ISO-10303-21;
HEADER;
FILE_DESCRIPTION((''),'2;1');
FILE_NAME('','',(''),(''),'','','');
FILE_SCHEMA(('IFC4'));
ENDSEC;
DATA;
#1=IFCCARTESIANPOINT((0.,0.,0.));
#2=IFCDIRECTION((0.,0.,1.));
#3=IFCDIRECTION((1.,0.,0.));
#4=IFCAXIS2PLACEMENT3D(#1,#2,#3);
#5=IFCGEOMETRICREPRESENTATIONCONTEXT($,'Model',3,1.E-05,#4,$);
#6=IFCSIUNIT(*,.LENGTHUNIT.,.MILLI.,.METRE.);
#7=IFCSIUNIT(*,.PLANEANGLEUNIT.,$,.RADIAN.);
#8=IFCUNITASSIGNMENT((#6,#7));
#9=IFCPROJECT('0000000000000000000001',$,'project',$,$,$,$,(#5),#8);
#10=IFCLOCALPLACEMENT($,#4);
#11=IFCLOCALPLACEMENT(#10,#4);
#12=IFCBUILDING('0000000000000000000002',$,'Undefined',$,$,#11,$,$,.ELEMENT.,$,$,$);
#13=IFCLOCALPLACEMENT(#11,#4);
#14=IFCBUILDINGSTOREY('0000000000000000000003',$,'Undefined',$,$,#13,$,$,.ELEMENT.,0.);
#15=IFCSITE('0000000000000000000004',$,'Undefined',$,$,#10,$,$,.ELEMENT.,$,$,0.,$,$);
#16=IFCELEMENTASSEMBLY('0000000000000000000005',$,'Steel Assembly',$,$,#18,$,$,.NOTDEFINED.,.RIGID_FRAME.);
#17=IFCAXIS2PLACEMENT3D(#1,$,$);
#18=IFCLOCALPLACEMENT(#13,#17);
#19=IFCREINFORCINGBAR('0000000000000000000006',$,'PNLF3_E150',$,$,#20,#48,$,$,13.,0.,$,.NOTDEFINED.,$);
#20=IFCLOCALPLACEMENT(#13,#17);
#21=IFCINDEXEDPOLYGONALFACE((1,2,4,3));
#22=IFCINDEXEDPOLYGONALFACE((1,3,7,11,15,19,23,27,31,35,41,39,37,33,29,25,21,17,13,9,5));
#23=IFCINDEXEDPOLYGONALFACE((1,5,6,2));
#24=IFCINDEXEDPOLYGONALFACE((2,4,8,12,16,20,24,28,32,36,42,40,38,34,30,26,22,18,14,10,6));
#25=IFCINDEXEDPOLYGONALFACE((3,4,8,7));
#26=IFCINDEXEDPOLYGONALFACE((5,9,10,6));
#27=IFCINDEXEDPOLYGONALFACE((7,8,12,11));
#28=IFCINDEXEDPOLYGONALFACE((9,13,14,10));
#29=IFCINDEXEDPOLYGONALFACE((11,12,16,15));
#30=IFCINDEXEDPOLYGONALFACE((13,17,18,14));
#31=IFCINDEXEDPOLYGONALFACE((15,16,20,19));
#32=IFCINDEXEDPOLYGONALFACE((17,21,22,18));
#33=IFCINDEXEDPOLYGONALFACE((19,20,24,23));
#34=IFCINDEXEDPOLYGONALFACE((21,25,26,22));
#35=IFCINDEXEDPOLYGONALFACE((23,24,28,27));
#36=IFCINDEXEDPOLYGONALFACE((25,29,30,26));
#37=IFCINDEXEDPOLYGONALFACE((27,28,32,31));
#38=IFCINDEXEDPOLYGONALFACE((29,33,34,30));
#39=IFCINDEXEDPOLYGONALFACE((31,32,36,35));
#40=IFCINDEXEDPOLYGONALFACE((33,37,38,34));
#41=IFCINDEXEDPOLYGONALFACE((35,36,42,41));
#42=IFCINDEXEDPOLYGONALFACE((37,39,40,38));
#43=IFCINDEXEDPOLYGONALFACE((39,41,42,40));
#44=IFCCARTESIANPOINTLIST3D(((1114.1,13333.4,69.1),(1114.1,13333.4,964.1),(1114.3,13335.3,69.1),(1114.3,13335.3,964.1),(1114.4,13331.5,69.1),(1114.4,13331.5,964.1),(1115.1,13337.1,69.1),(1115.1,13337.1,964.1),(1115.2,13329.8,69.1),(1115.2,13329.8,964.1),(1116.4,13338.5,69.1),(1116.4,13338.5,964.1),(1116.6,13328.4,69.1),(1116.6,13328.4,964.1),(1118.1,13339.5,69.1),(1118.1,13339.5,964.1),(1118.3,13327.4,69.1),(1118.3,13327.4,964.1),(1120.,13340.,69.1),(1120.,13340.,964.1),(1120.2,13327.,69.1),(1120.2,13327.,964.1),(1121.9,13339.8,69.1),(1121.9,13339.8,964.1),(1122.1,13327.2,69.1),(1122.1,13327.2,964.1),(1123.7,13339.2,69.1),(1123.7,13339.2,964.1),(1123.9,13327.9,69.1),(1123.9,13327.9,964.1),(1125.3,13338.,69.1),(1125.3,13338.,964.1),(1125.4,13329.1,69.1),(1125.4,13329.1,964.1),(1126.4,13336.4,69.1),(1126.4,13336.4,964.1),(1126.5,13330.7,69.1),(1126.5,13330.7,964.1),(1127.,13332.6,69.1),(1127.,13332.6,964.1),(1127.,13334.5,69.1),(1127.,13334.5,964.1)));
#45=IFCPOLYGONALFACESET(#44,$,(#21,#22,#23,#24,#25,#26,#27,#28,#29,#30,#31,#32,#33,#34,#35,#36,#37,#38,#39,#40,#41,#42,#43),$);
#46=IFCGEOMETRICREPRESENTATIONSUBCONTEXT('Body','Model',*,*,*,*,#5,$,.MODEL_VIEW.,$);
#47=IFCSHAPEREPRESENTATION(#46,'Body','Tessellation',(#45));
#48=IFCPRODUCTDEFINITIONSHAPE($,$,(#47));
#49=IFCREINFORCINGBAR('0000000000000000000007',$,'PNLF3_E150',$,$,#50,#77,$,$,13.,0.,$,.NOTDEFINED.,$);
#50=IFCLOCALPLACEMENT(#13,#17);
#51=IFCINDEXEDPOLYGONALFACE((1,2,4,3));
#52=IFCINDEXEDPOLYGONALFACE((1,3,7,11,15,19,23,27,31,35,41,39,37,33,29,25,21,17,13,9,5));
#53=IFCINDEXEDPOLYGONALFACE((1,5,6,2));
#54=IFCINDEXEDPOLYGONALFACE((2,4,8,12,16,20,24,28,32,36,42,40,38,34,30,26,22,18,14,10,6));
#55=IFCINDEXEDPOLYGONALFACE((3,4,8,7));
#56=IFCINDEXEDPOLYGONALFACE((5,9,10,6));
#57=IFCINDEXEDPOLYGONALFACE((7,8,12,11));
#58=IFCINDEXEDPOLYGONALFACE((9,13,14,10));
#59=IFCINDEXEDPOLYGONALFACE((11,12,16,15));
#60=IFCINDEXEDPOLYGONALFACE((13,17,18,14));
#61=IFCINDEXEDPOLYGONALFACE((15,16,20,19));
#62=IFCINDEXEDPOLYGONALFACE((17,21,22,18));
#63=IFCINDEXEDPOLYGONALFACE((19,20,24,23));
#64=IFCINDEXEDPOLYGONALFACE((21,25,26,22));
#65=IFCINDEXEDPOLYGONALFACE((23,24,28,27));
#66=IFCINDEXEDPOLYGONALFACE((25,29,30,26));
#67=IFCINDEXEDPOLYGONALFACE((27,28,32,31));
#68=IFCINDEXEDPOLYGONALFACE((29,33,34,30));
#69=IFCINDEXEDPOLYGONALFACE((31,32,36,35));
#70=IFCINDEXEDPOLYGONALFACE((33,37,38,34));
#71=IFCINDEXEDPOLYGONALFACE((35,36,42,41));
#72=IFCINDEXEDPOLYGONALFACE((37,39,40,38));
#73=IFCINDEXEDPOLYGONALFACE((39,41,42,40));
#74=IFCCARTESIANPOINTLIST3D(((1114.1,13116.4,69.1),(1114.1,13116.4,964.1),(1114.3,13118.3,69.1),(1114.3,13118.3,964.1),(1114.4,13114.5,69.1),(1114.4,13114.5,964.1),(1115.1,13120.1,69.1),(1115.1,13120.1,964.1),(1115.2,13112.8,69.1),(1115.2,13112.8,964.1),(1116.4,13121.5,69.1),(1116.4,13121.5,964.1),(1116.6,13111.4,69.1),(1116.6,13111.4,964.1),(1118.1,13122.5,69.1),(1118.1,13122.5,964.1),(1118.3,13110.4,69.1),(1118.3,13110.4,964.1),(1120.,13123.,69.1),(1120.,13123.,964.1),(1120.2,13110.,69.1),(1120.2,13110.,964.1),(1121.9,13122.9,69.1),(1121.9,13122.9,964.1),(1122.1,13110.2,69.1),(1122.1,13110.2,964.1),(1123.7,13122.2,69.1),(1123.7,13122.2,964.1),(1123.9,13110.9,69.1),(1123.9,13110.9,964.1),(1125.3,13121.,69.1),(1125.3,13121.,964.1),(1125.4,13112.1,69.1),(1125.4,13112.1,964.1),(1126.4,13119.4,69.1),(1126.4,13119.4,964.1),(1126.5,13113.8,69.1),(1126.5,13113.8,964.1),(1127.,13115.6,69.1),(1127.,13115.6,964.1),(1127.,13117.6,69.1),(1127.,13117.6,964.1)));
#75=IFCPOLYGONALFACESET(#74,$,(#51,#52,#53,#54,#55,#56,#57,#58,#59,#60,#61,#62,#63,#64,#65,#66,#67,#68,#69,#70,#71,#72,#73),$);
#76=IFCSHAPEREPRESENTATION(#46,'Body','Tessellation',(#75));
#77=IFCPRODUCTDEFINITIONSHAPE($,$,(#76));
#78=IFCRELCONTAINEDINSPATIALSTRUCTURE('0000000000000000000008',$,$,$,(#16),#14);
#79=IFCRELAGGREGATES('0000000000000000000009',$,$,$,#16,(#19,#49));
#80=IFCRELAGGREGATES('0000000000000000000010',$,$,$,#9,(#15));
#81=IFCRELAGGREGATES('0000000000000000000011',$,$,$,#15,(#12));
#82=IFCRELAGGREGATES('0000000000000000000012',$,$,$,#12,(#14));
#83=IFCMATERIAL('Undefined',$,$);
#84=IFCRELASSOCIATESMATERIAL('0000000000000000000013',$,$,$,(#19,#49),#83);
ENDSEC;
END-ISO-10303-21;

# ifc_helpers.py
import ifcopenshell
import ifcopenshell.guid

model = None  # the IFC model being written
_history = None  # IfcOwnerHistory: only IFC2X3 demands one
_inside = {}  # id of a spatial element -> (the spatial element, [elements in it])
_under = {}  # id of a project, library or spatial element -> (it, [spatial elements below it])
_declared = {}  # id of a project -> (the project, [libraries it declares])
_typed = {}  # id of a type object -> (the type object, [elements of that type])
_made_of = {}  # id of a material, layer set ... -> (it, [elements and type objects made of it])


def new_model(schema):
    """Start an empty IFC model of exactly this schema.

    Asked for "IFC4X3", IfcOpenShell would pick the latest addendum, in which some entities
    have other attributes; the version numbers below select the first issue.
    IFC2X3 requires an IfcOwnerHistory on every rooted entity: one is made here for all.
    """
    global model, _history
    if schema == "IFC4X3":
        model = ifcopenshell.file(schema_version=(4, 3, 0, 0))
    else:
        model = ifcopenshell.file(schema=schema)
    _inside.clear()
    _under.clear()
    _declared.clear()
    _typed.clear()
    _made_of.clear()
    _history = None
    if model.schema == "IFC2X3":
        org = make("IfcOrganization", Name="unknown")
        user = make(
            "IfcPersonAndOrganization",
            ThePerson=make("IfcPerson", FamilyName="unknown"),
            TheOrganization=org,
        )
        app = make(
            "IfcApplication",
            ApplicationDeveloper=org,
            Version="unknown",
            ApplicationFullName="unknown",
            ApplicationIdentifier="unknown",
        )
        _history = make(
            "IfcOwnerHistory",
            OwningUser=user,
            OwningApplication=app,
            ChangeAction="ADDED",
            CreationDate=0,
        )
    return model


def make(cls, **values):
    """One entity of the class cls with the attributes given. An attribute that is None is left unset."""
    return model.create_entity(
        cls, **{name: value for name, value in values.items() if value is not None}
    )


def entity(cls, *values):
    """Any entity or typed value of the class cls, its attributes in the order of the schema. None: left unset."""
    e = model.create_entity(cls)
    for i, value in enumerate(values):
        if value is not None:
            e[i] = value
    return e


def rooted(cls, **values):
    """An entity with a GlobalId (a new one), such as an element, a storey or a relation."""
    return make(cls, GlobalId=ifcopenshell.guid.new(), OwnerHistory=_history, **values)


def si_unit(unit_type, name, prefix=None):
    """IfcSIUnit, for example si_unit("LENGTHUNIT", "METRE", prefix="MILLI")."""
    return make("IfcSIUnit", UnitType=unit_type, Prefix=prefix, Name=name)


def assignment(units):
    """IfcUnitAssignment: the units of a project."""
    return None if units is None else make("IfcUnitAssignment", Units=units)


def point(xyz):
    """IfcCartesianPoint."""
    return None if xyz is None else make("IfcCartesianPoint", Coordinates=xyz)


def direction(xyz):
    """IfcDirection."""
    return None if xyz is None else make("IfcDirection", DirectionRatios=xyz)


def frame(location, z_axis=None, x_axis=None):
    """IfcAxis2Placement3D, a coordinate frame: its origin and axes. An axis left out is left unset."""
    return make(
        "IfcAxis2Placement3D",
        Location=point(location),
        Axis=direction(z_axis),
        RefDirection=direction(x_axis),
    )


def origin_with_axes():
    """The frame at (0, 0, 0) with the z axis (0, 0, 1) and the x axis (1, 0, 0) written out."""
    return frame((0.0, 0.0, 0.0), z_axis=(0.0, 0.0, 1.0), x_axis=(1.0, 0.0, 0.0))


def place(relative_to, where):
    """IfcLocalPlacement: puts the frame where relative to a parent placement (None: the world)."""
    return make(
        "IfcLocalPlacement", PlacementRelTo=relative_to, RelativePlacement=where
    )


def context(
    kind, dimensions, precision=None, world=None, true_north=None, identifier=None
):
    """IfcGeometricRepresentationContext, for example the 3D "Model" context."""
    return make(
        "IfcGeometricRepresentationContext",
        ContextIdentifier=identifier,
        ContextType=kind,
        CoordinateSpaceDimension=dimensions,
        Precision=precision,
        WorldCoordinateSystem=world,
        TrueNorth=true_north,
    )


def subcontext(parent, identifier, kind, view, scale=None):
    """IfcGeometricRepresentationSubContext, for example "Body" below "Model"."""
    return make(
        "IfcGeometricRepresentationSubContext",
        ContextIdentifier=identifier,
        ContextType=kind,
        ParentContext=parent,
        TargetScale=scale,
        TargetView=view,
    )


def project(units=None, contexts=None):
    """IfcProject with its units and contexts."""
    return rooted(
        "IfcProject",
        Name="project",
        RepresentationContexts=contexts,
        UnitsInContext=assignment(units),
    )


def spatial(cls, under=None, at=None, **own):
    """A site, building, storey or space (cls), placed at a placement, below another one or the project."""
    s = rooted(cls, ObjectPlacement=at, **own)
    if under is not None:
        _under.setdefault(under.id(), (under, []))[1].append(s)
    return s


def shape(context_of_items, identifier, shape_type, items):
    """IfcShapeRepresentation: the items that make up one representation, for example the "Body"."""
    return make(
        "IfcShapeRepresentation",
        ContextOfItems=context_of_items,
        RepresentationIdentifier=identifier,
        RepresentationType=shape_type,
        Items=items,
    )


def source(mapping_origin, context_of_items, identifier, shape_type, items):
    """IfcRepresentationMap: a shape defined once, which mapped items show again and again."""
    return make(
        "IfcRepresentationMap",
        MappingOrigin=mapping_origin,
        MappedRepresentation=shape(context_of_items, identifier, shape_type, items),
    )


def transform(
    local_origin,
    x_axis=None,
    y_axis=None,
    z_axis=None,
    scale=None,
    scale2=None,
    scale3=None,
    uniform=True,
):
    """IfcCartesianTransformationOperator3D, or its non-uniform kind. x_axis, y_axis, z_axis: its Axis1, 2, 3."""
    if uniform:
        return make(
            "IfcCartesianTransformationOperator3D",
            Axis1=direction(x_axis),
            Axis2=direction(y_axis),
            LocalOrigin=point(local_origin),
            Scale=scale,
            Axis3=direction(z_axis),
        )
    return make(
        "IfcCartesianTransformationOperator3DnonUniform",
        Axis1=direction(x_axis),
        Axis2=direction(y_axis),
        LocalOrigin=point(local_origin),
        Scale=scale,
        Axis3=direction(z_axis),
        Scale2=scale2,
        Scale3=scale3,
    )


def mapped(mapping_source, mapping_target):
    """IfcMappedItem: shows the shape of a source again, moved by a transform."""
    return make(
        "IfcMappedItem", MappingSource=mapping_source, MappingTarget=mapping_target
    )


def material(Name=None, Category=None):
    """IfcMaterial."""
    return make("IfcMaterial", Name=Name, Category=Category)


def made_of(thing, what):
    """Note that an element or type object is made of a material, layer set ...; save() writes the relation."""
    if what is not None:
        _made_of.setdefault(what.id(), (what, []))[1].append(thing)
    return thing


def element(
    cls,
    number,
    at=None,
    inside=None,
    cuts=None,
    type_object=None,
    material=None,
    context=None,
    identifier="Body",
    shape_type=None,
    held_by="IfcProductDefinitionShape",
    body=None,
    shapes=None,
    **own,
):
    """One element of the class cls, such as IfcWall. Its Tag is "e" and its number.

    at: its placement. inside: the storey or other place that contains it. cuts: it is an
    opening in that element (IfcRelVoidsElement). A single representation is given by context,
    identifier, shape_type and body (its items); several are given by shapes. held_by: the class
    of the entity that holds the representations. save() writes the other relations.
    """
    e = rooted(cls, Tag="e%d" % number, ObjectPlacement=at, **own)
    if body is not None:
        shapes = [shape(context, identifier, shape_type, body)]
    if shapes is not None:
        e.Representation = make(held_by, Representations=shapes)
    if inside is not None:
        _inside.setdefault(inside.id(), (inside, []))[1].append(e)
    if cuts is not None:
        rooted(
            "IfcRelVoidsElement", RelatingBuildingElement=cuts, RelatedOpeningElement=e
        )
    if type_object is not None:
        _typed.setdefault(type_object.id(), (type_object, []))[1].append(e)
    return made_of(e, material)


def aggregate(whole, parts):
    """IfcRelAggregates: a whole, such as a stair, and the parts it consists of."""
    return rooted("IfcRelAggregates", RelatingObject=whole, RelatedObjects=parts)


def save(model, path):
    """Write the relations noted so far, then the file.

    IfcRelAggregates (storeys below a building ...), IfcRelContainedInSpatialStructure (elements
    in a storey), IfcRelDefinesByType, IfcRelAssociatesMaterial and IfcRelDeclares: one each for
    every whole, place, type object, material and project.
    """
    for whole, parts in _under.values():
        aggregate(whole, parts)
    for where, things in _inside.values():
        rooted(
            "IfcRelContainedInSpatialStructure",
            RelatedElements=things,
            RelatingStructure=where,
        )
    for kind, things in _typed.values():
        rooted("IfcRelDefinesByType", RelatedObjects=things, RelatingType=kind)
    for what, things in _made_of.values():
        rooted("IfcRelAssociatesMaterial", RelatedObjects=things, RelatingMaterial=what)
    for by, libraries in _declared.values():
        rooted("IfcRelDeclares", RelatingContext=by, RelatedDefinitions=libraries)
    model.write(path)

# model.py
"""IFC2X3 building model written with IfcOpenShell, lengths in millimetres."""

from ifc_helpers import new_model, entity, si_unit, frame, origin_with_axes, place, context, subcontext, project, spatial, source, transform, mapped, material, element, aggregate, save


model = new_model("IFC2X3")

# Units and contexts
model_context = context("Model", 3, precision=1e-05, world=origin_with_axes())
body_context = subcontext(model_context, "Body", "Model", "MODEL_VIEW")
ifc_project = project(units=[si_unit("LENGTHUNIT", "METRE", prefix="MILLI"), si_unit("PLANEANGLEUNIT", "RADIAN")], contexts=[model_context])

# Site, building, storey
site_placement = place(None, origin_with_axes())
site = spatial("IfcSite", under=ifc_project, at=site_placement, Name="Undefined", CompositionType="ELEMENT", RefElevation=0.0)
building_placement = place(site_placement, origin_with_axes())
building = spatial("IfcBuilding", under=site, at=building_placement, Name="Undefined", CompositionType="ELEMENT")
storey_placement = place(building_placement, origin_with_axes())
storey = spatial("IfcBuildingStorey", under=building, at=storey_placement, Name="Undefined", CompositionType="ELEMENT", Elevation=0.0)

# Element assembly, reinforcing bars
ifc_material_1 = material(Name="Undefined")
assembly_1_placement = place(storey_placement, origin_with_axes())
assembly_1 = element("IfcElementAssembly", 1, at=assembly_1_placement, inside=storey, Name="Steel Assembly", AssemblyPlace="NOTDEFINED", PredefinedType="RIGID_FRAME")
shared_shape_1 = source(origin_with_axes(), body_context, "Body", "AdvancedSweptSolid", [
    entity("IfcSweptDiskSolid", entity("IfcTrimmedCurve", entity("IfcLine", entity("IfcCartesianPoint", [0.0, 0.0, 0.0]), entity("IfcVector", entity("IfcDirection", [1.0, 0.0, 0.0]), 1.0)), [entity("IfcParameterValue", 0.0)], [entity("IfcParameterValue", 895.0)], True, "PARAMETER"), 6.5, None, 0.0, 895.0),
])
reinforcing_bar_1_placement = place(assembly_1_placement, frame((1120.6, 13333.5, 964.1), z_axis=(-0.999922, -0.012456, 0.0), x_axis=(0.0, 0.0, -1.0)))
reinforcing_bar_1 = element("IfcReinforcingBar", 2, at=reinforcing_bar_1_placement, material=ifc_material_1, Name="PNLF3_E150", BarRole="NOTDEFINED", CrossSectionArea=0.0, NominalDiameter=13.0, context=body_context, shape_type="MappedRepresentation", body=[
    mapped(shared_shape_1, transform((0.0, 0.0, 0.0))),
])
shared_shape_2 = source(origin_with_axes(), body_context, "Body", "AdvancedSweptSolid", [
    entity("IfcSweptDiskSolid", entity("IfcTrimmedCurve", entity("IfcLine", entity("IfcCartesianPoint", [0.0, 0.0, 0.0]), entity("IfcVector", entity("IfcDirection", [1.0, 0.0, 0.0]), 1.0)), [entity("IfcParameterValue", 0.0)], [entity("IfcParameterValue", 895.0)], True, "PARAMETER"), 6.5, None, 0.0, 895.0),
])
reinforcing_bar_2_placement = place(assembly_1_placement, frame((1120.6, 13116.5, 964.1), z_axis=(-0.999922, -0.012456, 0.0), x_axis=(0.0, 0.0, -1.0)))
reinforcing_bar_2 = element("IfcReinforcingBar", 3, at=reinforcing_bar_2_placement, material=ifc_material_1, Name="PNLF3_E150", BarRole="NOTDEFINED", CrossSectionArea=0.0, NominalDiameter=13.0, context=body_context, shape_type="MappedRepresentation", body=[
    mapped(shared_shape_2, transform((0.0, 0.0, 0.0))),
])
aggregate(assembly_1, [reinforcing_bar_1, reinforcing_bar_2])

save(model, "model.ifc")
